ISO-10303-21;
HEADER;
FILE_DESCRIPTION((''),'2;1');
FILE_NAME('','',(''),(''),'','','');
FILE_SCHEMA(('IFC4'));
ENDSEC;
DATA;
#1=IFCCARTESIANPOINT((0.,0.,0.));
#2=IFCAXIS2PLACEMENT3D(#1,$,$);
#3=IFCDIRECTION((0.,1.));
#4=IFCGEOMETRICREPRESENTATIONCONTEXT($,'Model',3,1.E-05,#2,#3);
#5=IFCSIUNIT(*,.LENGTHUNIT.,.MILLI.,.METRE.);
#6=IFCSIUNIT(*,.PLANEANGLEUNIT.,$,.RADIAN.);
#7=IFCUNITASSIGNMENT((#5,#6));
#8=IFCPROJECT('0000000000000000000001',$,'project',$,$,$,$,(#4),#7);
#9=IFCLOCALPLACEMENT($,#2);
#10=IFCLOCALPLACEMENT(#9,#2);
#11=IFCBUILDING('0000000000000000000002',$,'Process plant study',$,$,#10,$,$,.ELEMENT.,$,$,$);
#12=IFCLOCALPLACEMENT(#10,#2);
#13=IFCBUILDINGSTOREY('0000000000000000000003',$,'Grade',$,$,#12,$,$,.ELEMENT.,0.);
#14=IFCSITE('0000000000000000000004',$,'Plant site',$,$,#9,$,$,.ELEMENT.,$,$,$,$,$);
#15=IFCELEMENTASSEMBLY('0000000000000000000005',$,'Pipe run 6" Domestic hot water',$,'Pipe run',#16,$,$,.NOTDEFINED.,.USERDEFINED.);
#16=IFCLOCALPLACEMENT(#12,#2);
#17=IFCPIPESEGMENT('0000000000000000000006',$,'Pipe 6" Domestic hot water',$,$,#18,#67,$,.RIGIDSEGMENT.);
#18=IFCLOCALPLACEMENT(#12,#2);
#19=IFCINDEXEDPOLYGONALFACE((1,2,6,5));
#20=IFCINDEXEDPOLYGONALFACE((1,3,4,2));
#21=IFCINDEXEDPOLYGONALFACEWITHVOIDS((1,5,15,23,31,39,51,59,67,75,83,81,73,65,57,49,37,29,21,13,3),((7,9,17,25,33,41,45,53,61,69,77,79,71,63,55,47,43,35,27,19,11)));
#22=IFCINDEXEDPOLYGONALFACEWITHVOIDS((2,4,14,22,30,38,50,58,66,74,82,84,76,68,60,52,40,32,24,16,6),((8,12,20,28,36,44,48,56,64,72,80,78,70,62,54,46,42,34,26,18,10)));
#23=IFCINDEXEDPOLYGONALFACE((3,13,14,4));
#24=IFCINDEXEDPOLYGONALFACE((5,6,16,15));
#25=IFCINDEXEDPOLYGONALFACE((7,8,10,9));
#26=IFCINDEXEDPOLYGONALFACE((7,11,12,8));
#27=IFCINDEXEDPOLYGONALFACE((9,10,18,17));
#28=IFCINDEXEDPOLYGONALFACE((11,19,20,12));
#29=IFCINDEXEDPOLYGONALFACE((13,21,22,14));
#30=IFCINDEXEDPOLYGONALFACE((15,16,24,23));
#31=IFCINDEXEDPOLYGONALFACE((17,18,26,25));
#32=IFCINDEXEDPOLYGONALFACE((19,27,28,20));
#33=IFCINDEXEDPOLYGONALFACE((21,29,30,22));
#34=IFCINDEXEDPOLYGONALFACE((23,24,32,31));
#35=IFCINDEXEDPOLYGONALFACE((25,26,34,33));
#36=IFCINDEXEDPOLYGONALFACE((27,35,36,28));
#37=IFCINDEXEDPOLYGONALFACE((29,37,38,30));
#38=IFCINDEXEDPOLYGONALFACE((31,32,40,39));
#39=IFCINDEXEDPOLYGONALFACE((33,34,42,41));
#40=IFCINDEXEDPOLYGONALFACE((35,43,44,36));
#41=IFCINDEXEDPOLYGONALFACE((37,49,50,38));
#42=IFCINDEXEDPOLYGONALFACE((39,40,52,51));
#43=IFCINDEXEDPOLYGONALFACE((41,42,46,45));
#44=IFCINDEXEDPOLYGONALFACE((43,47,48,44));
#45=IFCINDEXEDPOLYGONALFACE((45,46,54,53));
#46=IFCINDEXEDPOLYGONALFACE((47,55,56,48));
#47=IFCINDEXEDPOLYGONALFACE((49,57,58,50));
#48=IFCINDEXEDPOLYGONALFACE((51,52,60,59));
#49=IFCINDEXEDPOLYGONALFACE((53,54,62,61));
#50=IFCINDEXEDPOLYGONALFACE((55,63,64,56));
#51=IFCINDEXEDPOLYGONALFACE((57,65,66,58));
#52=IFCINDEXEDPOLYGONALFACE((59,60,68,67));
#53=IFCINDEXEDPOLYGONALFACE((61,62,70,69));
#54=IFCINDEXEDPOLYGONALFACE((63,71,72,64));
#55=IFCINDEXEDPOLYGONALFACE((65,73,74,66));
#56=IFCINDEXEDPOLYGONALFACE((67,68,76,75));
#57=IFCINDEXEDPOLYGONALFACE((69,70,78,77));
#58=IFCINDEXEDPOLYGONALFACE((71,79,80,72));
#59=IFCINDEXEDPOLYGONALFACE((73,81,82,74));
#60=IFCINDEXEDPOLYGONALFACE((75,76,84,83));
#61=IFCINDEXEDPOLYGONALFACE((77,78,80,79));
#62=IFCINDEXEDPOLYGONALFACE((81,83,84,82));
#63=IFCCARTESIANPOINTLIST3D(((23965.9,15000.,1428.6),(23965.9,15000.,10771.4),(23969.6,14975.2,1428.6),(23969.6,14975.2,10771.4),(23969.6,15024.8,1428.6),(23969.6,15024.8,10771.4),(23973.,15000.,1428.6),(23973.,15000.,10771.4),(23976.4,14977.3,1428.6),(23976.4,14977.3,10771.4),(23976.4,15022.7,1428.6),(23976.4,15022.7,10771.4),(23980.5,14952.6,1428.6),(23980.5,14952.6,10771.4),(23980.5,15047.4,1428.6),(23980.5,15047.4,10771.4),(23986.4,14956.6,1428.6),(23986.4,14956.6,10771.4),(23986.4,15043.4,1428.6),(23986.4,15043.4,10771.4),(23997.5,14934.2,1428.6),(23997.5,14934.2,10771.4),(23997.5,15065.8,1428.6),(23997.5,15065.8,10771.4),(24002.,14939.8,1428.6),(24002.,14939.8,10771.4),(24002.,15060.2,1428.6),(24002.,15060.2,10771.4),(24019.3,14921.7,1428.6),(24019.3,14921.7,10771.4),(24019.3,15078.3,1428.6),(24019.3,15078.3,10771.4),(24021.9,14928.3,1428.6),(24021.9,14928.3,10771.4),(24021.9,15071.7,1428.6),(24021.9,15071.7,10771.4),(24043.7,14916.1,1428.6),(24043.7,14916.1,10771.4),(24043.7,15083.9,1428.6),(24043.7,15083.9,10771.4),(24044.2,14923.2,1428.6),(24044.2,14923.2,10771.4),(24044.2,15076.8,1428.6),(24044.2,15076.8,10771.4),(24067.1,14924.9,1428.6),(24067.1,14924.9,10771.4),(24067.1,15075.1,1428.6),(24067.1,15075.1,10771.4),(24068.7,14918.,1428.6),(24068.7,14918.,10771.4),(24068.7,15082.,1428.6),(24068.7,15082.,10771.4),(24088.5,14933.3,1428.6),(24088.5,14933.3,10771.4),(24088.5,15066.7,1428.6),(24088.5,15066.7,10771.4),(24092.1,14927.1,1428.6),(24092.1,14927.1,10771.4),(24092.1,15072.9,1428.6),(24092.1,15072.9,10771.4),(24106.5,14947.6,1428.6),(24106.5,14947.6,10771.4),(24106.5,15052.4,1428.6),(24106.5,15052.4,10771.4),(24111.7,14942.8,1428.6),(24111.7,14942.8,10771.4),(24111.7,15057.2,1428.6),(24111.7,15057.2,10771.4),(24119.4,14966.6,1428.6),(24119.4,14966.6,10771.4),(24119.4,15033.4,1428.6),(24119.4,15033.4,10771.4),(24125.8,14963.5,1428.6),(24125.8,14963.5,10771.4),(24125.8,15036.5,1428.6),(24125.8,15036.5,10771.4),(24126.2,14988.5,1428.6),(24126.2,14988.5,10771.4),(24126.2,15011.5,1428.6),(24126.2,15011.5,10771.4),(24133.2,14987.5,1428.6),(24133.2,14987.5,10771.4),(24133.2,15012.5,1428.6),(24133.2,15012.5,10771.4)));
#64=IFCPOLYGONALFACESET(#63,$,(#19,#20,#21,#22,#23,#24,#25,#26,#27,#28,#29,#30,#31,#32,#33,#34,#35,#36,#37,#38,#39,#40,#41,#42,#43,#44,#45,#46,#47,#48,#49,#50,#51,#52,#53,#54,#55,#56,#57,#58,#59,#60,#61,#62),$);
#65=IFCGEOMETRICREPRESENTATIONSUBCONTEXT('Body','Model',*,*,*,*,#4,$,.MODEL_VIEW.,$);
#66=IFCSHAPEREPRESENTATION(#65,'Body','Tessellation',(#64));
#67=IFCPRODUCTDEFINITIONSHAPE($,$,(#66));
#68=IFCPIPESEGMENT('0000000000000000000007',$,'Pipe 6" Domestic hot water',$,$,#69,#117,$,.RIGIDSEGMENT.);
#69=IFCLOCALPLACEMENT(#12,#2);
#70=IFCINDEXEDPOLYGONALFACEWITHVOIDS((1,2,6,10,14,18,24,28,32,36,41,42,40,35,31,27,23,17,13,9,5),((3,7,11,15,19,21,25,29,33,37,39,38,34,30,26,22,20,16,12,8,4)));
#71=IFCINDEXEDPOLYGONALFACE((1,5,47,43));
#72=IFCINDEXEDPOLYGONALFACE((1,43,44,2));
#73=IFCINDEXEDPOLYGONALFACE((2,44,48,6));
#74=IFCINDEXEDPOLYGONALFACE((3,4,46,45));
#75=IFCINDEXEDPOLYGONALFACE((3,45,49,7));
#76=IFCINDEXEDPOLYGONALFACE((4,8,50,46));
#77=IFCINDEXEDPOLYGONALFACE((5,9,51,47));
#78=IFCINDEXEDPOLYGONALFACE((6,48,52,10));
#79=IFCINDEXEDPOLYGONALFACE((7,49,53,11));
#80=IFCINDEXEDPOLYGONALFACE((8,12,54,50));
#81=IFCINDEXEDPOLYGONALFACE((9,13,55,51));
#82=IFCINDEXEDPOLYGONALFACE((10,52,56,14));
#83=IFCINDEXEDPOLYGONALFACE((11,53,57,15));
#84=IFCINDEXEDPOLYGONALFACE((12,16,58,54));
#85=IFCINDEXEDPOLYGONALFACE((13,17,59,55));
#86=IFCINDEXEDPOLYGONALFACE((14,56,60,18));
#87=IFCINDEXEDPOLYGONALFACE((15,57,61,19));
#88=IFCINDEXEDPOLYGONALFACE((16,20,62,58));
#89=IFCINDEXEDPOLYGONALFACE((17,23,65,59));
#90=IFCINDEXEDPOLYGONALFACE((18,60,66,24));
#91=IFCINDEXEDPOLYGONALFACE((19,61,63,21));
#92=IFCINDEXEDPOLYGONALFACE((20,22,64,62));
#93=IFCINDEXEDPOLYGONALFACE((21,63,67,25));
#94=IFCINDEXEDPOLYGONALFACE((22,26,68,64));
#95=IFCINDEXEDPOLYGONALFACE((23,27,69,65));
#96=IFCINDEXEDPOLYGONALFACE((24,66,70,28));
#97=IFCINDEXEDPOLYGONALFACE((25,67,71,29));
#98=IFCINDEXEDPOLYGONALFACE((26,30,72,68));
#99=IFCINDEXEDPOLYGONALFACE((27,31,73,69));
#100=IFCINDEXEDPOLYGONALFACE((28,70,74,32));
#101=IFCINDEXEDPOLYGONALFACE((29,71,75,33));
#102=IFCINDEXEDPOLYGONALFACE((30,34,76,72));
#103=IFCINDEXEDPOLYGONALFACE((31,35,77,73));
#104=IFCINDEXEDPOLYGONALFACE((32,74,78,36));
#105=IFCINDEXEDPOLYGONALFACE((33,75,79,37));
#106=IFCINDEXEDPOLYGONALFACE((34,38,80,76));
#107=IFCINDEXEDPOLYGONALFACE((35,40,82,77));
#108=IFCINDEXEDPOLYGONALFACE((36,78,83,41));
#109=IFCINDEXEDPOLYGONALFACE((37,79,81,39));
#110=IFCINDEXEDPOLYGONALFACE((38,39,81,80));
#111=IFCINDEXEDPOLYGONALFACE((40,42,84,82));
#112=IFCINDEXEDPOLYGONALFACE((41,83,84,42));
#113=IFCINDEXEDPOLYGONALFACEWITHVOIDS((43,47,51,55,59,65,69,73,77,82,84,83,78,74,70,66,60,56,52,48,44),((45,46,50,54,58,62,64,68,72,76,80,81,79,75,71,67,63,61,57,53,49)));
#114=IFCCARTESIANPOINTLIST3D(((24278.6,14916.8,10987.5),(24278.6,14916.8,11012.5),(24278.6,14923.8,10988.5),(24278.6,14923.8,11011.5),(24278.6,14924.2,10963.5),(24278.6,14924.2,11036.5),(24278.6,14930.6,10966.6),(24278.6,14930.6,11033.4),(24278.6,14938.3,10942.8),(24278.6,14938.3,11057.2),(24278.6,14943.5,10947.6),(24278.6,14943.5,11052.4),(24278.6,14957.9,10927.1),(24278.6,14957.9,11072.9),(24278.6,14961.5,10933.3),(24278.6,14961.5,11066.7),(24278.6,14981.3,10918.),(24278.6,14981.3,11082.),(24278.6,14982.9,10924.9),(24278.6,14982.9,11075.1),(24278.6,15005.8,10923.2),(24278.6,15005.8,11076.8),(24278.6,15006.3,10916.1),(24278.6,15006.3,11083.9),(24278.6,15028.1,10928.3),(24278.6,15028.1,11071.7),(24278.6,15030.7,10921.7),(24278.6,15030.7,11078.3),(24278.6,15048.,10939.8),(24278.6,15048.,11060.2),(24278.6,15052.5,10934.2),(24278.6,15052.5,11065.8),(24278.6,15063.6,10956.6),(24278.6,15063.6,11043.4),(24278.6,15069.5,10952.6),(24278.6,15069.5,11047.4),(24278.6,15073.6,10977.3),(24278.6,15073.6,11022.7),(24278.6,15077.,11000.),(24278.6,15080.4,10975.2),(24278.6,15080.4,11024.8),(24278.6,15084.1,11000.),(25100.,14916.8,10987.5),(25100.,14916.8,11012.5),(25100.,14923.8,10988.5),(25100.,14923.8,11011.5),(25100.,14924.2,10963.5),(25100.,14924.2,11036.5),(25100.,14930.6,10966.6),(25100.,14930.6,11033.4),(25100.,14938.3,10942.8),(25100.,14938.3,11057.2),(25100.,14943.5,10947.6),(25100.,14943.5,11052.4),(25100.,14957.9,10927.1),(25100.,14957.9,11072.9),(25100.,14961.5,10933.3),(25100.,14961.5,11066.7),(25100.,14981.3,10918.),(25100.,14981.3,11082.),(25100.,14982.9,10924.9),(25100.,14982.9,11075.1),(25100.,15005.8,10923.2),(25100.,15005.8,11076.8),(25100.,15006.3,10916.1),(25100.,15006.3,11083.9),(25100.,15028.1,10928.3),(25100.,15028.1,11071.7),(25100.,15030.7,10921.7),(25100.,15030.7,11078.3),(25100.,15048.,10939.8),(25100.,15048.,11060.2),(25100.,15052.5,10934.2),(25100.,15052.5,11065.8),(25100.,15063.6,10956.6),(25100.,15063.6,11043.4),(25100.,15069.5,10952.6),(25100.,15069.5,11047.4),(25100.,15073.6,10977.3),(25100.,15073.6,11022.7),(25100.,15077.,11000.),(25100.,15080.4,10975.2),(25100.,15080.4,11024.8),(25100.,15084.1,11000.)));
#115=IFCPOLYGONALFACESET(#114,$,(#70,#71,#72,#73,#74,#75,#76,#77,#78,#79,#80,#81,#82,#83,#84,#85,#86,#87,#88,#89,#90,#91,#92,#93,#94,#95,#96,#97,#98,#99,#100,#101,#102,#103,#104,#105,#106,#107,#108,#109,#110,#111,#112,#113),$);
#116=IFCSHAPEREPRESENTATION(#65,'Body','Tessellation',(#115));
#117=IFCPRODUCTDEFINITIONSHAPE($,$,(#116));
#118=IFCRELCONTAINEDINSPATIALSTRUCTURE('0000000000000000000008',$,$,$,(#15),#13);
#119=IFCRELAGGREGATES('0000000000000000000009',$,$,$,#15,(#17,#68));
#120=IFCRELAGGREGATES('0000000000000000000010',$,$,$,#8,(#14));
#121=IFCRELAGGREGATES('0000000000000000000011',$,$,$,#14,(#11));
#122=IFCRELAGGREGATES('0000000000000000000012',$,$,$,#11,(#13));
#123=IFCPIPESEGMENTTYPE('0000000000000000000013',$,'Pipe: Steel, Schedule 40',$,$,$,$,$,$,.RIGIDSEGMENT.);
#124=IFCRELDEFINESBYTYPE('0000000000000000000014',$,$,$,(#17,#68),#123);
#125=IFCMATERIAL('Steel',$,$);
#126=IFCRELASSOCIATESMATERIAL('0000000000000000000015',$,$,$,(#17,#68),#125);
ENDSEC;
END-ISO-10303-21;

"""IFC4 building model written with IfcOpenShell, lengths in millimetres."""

from ifc_helpers import new_model, si_unit, direction, frame, origin, origin_with_axes, origin_2d, place, context, subcontext, project, spatial, hollow_circle, extrude, material, type_object, element, aggregate, save


model = new_model("IFC4")

# Units and contexts
model_context = context("Model", 3, precision=1e-05, world=origin(), true_north=direction((0.0, 1.0)))
body_context = subcontext(model_context, "Body", "Model", "MODEL_VIEW")
ifc_project = project(units=[si_unit("LENGTHUNIT", "METRE", prefix="MILLI"), si_unit("PLANEANGLEUNIT", "RADIAN")], contexts=[model_context])

# Site, building, storey
site_placement = place(None, origin())
site = spatial("IfcSite", under=ifc_project, at=site_placement, Name="Plant site", CompositionType="ELEMENT")
building_placement = place(site_placement, origin())
building = spatial("IfcBuilding", under=site, at=building_placement, Name="Process plant study", CompositionType="ELEMENT")
storey_placement = place(building_placement, origin())
storey = spatial("IfcBuildingStorey", under=building, at=storey_placement, Name="Grade", CompositionType="ELEMENT", Elevation=0.0)

# Element assembly, pipe segments
ifc_material = material(Name="Steel")
pipe_segment_type = type_object("IfcPipeSegmentType", Name="Pipe: Steel, Schedule 40", PredefinedType="RIGIDSEGMENT")
assembly_1_placement = place(storey_placement, origin_with_axes())
assembly_1 = element("IfcElementAssembly", 1, at=assembly_1_placement, inside=storey, Name="Pipe run 6\" Domestic hot water", ObjectType="Pipe run", AssemblyPlace="NOTDEFINED", PredefinedType="USERDEFINED")
pipe_segment_1_placement = place(storey_placement, origin_with_axes())
pipe_segment_1 = element("IfcPipeSegment", 2, at=pipe_segment_1_placement, type_object=pipe_segment_type, material=ifc_material, Name="Pipe 6\" Domestic hot water", PredefinedType="RIGIDSEGMENT", context=body_context, shape_type="SweptSolid", body=[
    extrude(hollow_circle(Radius=84.1, WallThickness=7.1, at=origin_2d()), frame((24050.0, 15000.0, 1428.6), z_axis=(0.0, 0.0, 1.0), x_axis=(-1.0, 0.0, 0.0)), (0.0, 0.0, 1.0), 9342.8),
])
pipe_segment_2_placement = place(storey_placement, origin_with_axes())
pipe_segment_2 = element("IfcPipeSegment", 3, at=pipe_segment_2_placement, type_object=pipe_segment_type, material=ifc_material, Name="Pipe 6\" Domestic hot water", PredefinedType="RIGIDSEGMENT", context=body_context, shape_type="SweptSolid", body=[
    extrude(hollow_circle(Radius=84.1, WallThickness=7.1, at=origin_2d()), frame((24278.6, 15000.0, 11000.0), z_axis=(1.0, 0.0, 0.0), x_axis=(0.0, 1.0, 0.0)), (0.0, 0.0, 1.0), 821.4),
])

aggregate(assembly_1, [pipe_segment_1, pipe_segment_2])

save(model, "model.ifc")
